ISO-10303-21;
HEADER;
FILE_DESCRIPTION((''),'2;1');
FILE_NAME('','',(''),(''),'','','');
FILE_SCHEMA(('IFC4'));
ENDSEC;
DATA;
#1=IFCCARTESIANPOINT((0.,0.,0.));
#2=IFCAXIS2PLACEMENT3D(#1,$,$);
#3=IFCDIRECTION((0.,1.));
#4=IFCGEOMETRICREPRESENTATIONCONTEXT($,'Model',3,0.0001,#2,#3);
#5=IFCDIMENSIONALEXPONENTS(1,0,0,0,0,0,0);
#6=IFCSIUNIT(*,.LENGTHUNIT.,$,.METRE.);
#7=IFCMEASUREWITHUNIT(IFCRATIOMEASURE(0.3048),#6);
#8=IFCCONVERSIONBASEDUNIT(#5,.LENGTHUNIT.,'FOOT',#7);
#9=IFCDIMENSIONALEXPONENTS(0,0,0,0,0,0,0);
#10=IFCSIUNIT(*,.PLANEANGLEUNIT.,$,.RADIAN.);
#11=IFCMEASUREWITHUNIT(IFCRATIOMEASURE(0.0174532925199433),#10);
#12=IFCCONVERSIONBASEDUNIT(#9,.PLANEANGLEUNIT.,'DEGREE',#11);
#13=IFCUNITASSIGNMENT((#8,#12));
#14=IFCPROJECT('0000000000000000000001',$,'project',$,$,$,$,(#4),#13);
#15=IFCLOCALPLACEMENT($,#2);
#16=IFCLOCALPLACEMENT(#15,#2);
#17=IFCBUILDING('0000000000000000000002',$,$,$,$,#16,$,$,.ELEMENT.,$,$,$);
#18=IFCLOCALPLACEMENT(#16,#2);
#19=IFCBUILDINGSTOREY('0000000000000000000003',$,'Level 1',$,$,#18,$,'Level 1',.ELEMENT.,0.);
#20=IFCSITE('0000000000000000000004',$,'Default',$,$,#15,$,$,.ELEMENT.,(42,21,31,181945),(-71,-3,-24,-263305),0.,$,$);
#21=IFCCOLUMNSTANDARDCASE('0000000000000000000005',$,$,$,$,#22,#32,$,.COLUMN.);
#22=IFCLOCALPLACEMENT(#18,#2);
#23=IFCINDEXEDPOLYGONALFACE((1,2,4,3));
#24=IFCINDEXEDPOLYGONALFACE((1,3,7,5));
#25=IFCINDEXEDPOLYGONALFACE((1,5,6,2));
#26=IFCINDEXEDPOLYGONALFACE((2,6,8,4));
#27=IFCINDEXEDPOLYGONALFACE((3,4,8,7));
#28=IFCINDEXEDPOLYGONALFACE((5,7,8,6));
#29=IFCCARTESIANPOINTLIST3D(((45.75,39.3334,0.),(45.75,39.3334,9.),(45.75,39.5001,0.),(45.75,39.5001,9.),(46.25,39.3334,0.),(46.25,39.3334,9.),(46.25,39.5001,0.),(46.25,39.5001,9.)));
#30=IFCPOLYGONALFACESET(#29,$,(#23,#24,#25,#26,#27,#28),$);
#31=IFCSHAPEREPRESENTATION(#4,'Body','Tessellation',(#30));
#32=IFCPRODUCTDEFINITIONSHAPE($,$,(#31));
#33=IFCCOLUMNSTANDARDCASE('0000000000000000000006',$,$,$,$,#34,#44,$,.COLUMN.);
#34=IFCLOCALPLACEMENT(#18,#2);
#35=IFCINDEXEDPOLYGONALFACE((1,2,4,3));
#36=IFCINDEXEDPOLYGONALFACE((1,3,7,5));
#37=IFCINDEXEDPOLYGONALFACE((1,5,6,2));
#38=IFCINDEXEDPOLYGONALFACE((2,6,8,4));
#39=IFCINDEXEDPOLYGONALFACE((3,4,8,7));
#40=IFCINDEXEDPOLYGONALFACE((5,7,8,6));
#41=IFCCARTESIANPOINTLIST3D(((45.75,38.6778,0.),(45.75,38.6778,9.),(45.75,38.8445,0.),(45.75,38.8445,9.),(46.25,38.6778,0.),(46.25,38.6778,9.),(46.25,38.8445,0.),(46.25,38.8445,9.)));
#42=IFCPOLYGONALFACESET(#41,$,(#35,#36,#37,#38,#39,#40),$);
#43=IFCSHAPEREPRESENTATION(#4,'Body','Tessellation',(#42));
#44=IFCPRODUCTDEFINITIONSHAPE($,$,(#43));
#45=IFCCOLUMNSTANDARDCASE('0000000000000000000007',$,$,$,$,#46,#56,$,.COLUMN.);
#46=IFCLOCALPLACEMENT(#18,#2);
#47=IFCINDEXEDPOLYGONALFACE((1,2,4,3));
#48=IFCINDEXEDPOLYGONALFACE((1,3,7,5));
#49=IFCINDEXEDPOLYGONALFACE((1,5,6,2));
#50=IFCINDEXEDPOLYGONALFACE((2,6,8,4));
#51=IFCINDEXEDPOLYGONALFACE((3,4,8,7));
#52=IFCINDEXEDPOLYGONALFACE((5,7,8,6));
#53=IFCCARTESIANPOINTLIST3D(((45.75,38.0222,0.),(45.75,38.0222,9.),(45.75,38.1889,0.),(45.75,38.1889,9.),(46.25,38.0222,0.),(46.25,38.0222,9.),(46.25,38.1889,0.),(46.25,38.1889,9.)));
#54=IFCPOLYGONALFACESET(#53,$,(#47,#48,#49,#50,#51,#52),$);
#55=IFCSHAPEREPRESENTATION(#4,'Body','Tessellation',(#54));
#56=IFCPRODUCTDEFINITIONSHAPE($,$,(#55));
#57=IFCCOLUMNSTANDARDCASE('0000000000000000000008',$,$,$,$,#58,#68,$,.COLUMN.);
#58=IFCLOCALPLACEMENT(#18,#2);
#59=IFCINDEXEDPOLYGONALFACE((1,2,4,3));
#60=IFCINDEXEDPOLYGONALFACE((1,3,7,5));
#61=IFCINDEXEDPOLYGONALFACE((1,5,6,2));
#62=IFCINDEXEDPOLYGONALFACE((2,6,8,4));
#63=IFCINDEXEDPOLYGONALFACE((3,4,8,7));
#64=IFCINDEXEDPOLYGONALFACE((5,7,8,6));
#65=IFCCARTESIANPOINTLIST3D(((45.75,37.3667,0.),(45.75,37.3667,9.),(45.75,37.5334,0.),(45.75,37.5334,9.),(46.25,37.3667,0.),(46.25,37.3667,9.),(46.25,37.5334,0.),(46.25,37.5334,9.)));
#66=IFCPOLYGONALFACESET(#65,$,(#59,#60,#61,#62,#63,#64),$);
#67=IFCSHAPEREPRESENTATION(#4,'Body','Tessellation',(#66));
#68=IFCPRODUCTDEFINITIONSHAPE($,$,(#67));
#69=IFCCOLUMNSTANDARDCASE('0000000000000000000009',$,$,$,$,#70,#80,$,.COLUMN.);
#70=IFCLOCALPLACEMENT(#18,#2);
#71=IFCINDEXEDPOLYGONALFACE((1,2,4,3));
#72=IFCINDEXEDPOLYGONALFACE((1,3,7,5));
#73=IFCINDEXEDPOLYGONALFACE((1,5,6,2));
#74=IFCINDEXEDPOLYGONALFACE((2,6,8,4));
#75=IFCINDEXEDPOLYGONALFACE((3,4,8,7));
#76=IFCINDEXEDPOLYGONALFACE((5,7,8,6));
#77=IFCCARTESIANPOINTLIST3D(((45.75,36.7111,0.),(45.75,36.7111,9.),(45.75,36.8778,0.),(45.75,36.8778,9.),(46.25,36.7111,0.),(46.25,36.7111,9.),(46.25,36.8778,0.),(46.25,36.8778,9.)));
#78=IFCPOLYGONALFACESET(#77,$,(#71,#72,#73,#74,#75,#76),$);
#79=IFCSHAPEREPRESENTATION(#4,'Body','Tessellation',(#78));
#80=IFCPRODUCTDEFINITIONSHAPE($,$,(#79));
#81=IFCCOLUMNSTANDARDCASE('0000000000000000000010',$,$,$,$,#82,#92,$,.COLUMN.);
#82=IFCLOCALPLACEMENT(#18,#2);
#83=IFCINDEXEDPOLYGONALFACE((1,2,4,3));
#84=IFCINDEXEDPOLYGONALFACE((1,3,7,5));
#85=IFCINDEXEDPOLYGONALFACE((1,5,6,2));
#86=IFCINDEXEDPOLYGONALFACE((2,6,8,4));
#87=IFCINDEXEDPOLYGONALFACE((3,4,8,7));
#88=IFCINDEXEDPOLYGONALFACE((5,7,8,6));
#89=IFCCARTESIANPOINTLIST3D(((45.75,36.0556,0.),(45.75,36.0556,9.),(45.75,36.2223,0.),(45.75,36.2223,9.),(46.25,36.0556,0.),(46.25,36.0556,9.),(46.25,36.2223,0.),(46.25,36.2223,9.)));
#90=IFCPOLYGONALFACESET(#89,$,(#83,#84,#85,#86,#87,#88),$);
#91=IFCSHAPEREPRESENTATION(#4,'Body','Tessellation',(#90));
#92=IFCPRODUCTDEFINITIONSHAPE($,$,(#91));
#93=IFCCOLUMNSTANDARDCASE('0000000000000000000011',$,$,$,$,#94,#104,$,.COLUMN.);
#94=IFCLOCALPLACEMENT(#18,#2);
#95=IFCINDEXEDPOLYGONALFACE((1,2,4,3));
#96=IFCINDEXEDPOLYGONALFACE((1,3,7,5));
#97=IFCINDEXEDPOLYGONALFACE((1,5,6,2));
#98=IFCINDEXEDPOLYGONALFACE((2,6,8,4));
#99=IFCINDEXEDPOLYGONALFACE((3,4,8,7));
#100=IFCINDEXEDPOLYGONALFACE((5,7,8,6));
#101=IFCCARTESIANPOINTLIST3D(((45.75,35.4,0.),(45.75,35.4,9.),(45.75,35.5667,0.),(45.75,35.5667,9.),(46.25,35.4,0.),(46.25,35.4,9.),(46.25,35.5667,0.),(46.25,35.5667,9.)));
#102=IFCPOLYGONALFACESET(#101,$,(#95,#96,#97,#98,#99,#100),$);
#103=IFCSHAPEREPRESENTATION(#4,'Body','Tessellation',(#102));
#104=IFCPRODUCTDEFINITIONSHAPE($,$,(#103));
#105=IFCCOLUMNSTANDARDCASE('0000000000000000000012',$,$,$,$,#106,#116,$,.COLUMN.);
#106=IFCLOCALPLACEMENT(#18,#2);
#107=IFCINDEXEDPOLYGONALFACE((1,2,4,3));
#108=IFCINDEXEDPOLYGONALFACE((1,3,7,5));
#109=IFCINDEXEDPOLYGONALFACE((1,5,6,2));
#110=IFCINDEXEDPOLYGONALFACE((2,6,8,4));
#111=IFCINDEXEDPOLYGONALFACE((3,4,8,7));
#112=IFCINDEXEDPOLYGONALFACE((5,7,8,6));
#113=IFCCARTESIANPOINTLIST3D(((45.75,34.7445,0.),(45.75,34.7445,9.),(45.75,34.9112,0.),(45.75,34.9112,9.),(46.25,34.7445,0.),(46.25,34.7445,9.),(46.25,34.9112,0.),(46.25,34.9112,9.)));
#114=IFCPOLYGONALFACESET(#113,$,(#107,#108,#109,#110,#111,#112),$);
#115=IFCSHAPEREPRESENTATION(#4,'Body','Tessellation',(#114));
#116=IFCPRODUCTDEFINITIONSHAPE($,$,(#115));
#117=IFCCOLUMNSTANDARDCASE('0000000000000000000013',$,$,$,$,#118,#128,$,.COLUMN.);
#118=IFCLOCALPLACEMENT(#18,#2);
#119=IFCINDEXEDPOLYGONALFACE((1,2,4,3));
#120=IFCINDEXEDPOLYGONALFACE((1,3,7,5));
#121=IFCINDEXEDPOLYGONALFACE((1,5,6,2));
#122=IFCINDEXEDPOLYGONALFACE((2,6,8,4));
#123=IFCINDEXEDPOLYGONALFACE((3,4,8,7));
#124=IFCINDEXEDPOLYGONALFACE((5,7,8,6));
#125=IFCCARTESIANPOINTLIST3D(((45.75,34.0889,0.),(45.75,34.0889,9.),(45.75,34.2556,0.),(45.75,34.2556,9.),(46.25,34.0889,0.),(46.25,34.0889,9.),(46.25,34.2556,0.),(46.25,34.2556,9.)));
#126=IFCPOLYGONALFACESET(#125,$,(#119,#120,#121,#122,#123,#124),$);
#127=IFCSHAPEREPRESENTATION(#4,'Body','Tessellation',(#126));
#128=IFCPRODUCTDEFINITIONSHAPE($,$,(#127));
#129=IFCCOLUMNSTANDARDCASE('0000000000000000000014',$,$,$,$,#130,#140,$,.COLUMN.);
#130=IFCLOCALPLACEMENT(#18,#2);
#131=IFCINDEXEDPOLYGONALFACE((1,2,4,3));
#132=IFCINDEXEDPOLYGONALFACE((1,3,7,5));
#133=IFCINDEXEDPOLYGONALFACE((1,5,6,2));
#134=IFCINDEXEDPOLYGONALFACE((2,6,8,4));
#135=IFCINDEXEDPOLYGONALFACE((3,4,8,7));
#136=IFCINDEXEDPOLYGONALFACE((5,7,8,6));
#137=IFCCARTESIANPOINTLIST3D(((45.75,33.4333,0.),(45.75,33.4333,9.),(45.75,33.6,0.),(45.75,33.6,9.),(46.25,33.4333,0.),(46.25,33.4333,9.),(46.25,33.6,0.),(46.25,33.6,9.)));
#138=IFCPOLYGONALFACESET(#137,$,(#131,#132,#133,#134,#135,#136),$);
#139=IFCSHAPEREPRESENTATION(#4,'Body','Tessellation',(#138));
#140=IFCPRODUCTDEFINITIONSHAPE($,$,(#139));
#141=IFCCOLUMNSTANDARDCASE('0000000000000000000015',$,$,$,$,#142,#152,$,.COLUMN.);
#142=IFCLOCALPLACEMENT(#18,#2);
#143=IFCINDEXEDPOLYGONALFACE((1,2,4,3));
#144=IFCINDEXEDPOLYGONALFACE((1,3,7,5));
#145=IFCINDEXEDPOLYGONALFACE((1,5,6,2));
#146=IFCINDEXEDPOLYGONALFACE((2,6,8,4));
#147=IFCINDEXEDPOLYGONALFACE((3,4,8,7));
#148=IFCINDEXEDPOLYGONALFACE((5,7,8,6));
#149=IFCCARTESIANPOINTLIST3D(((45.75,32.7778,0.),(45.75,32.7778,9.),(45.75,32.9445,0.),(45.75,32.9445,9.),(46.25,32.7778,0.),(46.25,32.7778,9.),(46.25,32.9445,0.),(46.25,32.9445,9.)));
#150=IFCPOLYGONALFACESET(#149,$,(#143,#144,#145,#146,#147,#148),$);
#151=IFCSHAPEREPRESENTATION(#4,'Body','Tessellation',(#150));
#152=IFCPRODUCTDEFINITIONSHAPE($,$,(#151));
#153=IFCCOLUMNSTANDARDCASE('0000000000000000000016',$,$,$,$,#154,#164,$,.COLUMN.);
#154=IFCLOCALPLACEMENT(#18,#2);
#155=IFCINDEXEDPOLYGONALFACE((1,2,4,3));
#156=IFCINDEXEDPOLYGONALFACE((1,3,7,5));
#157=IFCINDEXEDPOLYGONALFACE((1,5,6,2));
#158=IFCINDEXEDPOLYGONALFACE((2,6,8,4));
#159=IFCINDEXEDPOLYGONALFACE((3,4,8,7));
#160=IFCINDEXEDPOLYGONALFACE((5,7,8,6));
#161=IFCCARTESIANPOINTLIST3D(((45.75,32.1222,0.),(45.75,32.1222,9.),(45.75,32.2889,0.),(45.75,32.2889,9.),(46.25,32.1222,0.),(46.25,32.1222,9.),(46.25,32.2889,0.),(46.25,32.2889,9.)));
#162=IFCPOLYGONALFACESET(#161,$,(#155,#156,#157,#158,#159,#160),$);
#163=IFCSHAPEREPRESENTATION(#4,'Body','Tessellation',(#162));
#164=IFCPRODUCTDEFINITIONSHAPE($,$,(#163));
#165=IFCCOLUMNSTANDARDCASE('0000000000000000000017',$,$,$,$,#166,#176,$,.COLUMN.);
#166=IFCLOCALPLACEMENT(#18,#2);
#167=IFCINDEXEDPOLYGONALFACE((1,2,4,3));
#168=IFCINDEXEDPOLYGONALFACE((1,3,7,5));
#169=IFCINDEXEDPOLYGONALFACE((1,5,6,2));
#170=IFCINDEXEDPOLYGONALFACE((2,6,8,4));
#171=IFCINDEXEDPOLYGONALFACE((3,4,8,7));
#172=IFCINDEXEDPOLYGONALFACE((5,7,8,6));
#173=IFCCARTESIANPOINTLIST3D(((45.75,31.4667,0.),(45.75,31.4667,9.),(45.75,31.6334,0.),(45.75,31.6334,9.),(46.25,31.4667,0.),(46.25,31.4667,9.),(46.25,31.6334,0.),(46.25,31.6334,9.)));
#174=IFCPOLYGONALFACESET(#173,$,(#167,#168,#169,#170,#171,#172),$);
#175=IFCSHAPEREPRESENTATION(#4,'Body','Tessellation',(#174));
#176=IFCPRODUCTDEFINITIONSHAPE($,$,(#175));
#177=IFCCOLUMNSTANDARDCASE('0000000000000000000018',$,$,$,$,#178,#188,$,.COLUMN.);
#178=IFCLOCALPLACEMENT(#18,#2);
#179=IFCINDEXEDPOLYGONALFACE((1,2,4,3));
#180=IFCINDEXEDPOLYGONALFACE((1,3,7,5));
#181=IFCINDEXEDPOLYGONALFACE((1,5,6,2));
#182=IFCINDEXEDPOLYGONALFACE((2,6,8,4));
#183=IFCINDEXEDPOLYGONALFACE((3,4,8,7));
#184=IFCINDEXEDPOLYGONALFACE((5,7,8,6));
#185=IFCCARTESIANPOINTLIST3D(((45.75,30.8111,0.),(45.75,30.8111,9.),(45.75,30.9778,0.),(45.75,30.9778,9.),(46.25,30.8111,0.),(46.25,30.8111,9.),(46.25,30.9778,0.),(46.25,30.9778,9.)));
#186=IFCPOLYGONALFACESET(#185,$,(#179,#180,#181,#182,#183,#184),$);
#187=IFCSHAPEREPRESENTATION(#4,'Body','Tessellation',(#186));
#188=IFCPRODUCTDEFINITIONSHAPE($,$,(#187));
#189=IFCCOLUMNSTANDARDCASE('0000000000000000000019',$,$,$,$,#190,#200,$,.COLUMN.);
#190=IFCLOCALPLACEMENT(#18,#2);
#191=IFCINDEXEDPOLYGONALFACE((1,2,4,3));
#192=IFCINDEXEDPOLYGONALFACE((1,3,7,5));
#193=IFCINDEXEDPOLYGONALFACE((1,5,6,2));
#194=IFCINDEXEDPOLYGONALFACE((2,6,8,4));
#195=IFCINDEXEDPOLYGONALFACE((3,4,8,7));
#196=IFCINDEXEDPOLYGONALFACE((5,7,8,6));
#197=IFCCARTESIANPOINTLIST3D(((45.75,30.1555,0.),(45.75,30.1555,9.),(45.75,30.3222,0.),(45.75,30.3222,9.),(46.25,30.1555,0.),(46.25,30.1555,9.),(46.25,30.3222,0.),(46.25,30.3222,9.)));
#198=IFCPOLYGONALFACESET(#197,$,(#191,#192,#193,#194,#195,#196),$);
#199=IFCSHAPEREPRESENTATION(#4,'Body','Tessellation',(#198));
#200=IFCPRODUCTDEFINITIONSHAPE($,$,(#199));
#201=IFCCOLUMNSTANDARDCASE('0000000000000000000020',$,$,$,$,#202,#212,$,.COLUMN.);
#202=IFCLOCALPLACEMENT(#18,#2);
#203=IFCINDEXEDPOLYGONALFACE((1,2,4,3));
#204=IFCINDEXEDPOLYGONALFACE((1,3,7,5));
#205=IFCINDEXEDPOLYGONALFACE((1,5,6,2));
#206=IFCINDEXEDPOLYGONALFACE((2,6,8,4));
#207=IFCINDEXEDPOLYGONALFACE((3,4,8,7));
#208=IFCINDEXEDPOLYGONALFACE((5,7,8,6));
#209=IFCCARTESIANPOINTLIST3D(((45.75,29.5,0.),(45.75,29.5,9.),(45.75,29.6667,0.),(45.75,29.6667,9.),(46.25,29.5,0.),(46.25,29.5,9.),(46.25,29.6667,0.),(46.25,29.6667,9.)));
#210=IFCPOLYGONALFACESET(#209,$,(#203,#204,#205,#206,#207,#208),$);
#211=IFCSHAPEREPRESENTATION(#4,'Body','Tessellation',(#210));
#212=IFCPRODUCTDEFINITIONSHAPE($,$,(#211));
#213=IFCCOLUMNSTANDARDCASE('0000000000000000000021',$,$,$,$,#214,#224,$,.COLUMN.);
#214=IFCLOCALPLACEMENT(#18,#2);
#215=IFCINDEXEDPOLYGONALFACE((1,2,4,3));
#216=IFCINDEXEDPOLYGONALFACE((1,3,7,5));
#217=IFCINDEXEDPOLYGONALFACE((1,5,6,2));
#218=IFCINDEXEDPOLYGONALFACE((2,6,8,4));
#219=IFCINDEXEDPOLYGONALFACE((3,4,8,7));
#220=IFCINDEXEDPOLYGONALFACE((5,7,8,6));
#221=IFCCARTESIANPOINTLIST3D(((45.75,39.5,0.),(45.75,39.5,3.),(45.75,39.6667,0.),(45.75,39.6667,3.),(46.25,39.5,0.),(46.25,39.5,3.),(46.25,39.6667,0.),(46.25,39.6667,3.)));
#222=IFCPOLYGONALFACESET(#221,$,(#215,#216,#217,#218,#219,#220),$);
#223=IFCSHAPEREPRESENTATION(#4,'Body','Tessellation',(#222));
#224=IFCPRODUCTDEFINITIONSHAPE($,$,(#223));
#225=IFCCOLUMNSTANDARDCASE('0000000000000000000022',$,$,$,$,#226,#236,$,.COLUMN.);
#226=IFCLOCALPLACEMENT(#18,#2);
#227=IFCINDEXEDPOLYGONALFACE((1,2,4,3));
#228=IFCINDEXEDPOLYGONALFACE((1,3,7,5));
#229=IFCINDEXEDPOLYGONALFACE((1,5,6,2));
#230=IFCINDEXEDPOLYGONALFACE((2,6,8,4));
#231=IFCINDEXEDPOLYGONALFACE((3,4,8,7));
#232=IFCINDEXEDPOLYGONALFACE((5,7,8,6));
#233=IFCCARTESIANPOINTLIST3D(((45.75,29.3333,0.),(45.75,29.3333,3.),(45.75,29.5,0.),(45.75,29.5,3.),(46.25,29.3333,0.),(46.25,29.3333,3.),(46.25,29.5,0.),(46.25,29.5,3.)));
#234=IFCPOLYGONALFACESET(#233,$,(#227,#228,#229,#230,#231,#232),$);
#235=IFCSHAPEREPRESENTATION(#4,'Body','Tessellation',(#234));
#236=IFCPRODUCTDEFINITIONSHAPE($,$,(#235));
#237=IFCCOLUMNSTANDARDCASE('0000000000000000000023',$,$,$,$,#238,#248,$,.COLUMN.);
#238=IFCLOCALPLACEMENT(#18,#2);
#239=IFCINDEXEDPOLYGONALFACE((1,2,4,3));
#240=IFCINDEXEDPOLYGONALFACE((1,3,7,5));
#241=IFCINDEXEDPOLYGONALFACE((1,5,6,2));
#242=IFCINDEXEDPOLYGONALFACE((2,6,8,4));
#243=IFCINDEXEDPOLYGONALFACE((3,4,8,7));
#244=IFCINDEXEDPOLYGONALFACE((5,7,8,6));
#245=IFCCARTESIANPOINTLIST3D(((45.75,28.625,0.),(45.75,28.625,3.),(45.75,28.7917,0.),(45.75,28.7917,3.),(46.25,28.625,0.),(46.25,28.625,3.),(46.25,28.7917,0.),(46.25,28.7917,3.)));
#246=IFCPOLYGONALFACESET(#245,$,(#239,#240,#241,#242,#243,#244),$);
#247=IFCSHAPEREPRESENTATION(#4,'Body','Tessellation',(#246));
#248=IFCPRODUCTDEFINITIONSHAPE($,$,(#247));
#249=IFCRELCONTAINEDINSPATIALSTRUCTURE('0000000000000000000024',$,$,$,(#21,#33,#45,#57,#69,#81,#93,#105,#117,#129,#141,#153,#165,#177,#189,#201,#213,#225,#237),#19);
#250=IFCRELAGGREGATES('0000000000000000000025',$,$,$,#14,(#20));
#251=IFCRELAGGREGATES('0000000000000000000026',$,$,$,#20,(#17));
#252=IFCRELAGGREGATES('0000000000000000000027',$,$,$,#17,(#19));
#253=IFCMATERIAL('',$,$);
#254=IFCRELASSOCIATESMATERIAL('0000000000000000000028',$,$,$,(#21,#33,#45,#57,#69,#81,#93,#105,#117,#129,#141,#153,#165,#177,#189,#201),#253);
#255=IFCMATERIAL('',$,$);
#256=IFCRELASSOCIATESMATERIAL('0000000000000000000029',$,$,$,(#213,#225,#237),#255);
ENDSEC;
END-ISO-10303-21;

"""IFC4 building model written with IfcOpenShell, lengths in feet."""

from ifc_helpers import new_model, entity, si_unit, converted_unit, direction, frame, origin, place, context, project, spatial, rectangle, extrude, material, element, save


model = new_model("IFC4")

# Units and contexts
model_context = context("Model", 3, precision=0.0001, world=origin(), true_north=direction((0.0, 1.0)))
ifc_project = project(units=[converted_unit("LENGTHUNIT", "FOOT", entity("IfcRatioMeasure", 0.3048), si_unit("LENGTHUNIT", "METRE"), dimensions=[1, 0, 0, 0, 0, 0, 0]), converted_unit("PLANEANGLEUNIT", "DEGREE", entity("IfcRatioMeasure", 0.0174532925199433), si_unit("PLANEANGLEUNIT", "RADIAN"), dimensions=[0, 0, 0, 0, 0, 0, 0])], contexts=[model_context])

# Site, building, storey
site_placement = place(None, origin())
site = spatial("IfcSite", under=ifc_project, at=site_placement, Name="Default", CompositionType="ELEMENT", RefLatitude=(42, 21, 31, 181945), RefLongitude=(-71, -3, -24, -263305), RefElevation=0.0)
building_placement = place(site_placement, origin())
building = spatial("IfcBuilding", under=site, at=building_placement, CompositionType="ELEMENT")
storey_placement = place(building_placement, origin())
storey = spatial("IfcBuildingStorey", under=building, at=storey_placement, Name="Level 1", LongName="Level 1", CompositionType="ELEMENT", Elevation=0.0)

# Columns
ifc_material_1 = material(Name="")
placement_1 = place(storey_placement, frame((46.0, 46.25, 0.0), z_axis=(0.0, 0.0, 1.0), x_axis=(0.0, -1.0, 0.0)))
for number, where, z_axis, x_axis in (
    (1, (6.8333, 0.0, 0.0), (0.0, 0.0, 1.0), (1.0, 0.0, 0.0)),
    (2, (7.4889, 0.0, 0.0), (0.0, 0.0, 1.0), (1.0, 0.0, 0.0)),
    (3, (8.1445, 0.0, 0.0), (0.0, 0.0, 1.0), (1.0, 0.0, 0.0)),
    (4, (8.8, 0.0, 0.0), (0.0, 0.0, 1.0), (1.0, 0.0, 0.0)),
    (5, (9.4556, 0.0, 0.0), (0.0, 0.0, 1.0), (1.0, 0.0, 0.0)),
    (6, (10.1111, 0.0, 0.0), (0.0, 0.0, 1.0), (1.0, 0.0, 0.0)),
    (7, (10.7667, 0.0, 0.0), (0.0, 0.0, 1.0), (1.0, 0.0, 0.0)),
    (8, (11.4222, 0.0, 0.0), (0.0, 0.0, 1.0), (1.0, 0.0, 0.0)),
    (9, (12.0778, 0.0, 0.0), (0.0, 0.0, 1.0), (1.0, 0.0, 0.0)),
    (10, (12.7334, 0.0, 0.0), (0.0, 0.0, 1.0), (1.0, 0.0, 0.0)),
    (11, (13.3889, 0.0, 0.0), (0.0, 0.0, 1.0), (1.0, 0.0, 0.0)),
    (12, (14.0445, 0.0, 0.0), (0.0, 0.0, 1.0), (1.0, 0.0, 0.0)),
    (13, (14.7, 0.0, 0.0), (0.0, 0.0, 1.0), (1.0, 0.0, 0.0)),
    (14, (15.3556, 0.0, 0.0), (0.0, 0.0, 1.0), (1.0, 0.0, 0.0)),
    (15, (16.0112, 0.0, 0.0), (0.0, 0.0, 1.0), (1.0, 0.0, 0.0)),
    (16, (16.6667, 0.0, 0.0), (0.0, 0.0, 1.0), (1.0, 0.0, 0.0)),
):
    element("IfcColumnStandardCase", number, at=place(placement_1, frame(where, z_axis=z_axis, x_axis=x_axis)), inside=storey, material=ifc_material_1, PredefinedType="COLUMN", context=model_context, shape_type="SweptSolid", body=[
        extrude(rectangle(XDim=0.1667, YDim=0.5), origin(), (0.0, 0.0, 1.0), 9.0),
    ])
ifc_material_2 = material(Name="")
for number, where, z_axis, x_axis in (
    (17, (6.6667, 0.0, 0.0), (0.0, 0.0, 1.0), (1.0, 0.0, 0.0)),
    (18, (16.8334, 0.0, 0.0), (0.0, 0.0, 1.0), (1.0, 0.0, 0.0)),
    (19, (17.5417, 0.0, 0.0), (0.0, 0.0, 1.0), (1.0, 0.0, 0.0)),
):
    element("IfcColumnStandardCase", number, at=place(placement_1, frame(where, z_axis=z_axis, x_axis=x_axis)), inside=storey, material=ifc_material_2, PredefinedType="COLUMN", context=model_context, shape_type="SweptSolid", body=[
        extrude(rectangle(XDim=0.1667, YDim=0.5), origin(), (0.0, 0.0, 1.0), 3.0),
    ])

save(model, "model.ifc")
